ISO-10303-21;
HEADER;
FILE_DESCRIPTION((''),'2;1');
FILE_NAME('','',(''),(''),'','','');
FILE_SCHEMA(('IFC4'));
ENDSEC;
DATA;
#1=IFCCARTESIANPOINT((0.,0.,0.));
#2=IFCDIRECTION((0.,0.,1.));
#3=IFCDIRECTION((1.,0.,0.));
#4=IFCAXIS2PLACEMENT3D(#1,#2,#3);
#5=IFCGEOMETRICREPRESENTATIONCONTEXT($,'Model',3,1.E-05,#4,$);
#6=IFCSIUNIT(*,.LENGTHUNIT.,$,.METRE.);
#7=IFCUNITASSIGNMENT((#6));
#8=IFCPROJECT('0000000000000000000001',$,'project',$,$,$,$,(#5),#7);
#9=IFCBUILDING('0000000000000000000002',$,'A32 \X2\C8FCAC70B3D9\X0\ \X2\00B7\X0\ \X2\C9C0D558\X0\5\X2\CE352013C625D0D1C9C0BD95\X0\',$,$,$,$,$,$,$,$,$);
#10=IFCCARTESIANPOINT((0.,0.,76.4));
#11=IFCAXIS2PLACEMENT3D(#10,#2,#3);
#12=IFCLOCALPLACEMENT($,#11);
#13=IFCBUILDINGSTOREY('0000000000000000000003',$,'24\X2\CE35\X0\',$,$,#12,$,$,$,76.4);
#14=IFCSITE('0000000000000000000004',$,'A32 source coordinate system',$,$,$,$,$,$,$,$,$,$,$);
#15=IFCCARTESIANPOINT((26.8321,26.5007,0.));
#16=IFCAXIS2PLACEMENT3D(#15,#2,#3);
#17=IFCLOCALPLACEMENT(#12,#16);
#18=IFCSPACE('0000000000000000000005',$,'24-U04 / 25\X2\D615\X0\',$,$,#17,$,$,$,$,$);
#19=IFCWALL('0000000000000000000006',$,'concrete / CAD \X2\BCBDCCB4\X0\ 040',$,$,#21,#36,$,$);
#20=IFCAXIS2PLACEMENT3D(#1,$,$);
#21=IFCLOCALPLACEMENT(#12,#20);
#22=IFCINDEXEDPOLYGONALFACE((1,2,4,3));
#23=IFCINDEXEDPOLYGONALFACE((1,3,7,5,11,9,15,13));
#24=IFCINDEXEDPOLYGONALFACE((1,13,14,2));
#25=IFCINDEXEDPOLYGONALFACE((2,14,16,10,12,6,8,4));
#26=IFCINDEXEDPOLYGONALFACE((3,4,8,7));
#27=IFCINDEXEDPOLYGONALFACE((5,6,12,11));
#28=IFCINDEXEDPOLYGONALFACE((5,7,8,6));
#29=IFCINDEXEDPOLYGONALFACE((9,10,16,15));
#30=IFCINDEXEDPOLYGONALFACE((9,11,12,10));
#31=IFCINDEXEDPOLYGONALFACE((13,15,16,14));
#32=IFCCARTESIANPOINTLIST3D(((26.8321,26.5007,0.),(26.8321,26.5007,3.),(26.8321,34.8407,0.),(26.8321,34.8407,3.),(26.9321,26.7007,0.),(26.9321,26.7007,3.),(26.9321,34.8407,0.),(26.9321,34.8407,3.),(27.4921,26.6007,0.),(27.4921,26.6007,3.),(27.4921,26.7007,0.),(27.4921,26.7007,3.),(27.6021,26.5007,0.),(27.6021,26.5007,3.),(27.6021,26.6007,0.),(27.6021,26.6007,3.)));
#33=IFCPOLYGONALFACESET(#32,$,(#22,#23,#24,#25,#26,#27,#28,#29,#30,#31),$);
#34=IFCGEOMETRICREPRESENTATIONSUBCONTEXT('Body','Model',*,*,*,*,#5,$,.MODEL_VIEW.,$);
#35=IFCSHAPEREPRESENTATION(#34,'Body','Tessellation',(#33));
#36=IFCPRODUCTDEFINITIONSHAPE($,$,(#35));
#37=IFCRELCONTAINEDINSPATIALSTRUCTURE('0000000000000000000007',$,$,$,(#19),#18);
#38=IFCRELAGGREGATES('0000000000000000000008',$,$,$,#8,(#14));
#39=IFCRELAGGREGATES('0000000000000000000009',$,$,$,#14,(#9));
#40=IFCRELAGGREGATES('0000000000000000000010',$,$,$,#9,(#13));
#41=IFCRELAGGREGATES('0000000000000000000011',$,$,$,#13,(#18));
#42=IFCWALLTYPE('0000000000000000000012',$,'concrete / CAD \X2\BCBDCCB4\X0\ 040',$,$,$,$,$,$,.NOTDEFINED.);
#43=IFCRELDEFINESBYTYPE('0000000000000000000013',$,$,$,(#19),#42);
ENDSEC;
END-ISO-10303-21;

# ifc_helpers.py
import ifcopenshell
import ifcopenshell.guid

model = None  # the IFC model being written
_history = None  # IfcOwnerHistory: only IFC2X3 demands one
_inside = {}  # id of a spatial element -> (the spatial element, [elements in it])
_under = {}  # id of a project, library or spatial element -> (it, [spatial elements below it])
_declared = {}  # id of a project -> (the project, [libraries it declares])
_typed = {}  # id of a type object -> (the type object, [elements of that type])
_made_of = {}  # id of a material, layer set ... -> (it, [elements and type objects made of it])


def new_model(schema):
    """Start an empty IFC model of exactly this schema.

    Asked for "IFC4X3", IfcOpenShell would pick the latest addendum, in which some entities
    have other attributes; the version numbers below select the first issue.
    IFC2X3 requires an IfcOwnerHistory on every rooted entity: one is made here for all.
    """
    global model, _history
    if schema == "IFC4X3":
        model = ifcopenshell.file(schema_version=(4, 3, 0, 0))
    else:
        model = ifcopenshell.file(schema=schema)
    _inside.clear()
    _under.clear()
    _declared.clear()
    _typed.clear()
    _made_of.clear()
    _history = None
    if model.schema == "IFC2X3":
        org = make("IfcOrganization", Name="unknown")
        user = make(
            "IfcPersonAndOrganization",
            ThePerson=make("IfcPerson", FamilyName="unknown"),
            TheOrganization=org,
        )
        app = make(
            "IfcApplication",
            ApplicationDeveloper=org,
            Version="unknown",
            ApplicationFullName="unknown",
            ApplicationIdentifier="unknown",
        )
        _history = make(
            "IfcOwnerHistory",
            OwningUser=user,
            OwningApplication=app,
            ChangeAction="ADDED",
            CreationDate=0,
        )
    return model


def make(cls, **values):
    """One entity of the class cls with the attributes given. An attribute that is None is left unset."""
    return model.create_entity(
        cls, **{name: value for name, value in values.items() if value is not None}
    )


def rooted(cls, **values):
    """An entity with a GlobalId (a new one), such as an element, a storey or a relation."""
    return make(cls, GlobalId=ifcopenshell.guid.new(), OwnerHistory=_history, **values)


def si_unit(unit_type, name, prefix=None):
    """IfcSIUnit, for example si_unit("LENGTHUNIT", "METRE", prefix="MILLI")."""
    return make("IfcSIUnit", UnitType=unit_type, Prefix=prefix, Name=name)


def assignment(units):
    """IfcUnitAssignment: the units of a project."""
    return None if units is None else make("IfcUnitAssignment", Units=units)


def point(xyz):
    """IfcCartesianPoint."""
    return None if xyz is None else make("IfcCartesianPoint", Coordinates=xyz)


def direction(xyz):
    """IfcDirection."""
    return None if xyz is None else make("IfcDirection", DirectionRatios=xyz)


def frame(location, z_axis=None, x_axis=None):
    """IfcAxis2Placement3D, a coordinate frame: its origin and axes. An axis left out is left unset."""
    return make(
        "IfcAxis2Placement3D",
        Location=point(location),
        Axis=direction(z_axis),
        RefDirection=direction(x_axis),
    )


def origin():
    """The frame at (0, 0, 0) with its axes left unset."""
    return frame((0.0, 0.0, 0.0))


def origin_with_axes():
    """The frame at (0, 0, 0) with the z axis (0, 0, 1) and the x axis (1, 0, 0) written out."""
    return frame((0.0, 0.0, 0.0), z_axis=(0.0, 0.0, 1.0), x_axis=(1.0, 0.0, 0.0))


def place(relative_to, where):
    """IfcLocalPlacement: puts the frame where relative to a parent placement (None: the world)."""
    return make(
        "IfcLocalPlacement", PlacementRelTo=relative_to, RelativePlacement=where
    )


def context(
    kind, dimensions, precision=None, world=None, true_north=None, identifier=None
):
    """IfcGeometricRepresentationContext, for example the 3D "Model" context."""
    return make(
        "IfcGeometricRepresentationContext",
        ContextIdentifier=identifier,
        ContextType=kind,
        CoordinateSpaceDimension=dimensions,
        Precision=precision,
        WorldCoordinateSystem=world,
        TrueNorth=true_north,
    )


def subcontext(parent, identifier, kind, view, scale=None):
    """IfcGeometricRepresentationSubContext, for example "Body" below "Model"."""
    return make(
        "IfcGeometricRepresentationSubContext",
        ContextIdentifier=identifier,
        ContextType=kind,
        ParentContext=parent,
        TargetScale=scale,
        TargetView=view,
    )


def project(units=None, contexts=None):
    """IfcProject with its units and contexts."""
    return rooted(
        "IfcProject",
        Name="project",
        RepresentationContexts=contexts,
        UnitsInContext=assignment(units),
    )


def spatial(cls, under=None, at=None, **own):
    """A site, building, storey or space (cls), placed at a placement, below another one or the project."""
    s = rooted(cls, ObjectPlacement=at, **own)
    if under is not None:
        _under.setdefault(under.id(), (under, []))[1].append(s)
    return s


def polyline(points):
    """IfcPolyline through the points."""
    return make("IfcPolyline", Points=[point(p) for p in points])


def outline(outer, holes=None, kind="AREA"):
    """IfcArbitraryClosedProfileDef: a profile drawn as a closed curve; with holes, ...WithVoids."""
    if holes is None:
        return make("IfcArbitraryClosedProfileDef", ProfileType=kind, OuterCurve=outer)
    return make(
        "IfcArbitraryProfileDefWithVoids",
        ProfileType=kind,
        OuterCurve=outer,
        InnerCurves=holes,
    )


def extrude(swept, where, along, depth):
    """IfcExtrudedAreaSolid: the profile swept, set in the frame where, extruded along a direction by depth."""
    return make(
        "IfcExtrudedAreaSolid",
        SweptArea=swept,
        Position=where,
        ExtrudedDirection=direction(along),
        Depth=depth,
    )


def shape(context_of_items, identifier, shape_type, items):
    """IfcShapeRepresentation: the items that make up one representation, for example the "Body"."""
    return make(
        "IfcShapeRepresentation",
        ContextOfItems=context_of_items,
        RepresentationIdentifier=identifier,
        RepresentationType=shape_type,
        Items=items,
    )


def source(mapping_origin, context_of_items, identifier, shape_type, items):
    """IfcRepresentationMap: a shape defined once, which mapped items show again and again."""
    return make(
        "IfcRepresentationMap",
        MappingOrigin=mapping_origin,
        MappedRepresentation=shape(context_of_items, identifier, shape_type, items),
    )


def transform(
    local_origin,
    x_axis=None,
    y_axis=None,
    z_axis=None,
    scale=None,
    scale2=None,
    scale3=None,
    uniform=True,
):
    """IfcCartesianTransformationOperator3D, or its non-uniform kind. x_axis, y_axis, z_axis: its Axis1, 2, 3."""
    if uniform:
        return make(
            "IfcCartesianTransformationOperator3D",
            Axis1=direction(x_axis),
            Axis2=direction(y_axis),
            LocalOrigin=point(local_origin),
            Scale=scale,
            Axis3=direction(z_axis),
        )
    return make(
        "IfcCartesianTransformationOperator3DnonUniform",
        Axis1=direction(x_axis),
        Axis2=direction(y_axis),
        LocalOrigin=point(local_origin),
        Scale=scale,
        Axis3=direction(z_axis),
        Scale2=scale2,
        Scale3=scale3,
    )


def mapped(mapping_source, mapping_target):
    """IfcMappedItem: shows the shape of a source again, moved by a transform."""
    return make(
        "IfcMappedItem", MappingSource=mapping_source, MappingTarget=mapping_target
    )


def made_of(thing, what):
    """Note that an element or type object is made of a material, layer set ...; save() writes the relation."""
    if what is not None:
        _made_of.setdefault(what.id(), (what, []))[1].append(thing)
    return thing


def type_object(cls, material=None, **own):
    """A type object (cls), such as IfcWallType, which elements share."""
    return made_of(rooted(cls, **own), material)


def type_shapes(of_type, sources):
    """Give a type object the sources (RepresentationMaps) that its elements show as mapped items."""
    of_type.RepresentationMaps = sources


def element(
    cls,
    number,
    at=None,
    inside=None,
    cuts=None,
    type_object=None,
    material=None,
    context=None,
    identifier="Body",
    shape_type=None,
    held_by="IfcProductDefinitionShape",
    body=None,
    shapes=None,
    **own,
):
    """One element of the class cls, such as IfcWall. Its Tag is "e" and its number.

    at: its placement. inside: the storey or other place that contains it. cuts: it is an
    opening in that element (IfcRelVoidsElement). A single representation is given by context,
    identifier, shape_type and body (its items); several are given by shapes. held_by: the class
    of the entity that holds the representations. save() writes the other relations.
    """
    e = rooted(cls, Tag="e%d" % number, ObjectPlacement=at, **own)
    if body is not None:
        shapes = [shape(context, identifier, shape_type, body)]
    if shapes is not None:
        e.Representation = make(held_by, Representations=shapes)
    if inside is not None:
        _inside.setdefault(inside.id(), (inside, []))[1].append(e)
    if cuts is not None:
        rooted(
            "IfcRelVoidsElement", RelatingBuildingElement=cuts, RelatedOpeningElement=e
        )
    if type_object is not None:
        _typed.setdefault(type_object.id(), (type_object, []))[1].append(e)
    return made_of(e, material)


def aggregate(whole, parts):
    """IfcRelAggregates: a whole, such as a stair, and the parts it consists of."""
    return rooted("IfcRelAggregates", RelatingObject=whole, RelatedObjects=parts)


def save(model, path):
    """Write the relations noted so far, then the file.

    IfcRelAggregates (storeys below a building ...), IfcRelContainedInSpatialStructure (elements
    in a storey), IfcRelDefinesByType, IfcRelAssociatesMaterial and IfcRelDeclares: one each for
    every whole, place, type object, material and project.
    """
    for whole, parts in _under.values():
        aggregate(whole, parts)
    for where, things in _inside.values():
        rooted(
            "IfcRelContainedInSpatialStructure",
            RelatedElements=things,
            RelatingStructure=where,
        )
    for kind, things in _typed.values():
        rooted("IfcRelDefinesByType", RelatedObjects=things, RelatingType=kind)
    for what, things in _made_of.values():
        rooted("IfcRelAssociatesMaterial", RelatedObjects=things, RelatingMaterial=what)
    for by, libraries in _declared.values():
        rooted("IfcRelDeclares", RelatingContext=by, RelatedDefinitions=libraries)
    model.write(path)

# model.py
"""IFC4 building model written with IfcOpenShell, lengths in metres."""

from ifc_helpers import new_model, si_unit, frame, origin, origin_with_axes, place, context, subcontext, project, spatial, polyline, outline, extrude, source, transform, mapped, type_object, type_shapes, element, save


model = new_model("IFC4")

# Units and contexts
model_context = context("Model", 3, precision=1e-05, world=origin_with_axes())
body_context = subcontext(model_context, "Body", "Model", "MODEL_VIEW")
ifc_project = project(units=[si_unit("LENGTHUNIT", "METRE")], contexts=[model_context])

# Site, building, storey, space
site = spatial("IfcSite", under=ifc_project, Name="A32 source coordinate system")
building = spatial("IfcBuilding", under=site, Name="A32 주거동 · 지하5층–옥탑지붕")
storey_placement = place(None, frame((0.0, 0.0, 76.4), z_axis=(0.0, 0.0, 1.0), x_axis=(1.0, 0.0, 0.0)))
storey = spatial("IfcBuildingStorey", under=building, at=storey_placement, Name="24층", Elevation=76.4)
space_1_placement = place(storey_placement, frame((26.8321, 26.5007, 0.0), z_axis=(0.0, 0.0, 1.0), x_axis=(1.0, 0.0, 0.0)))
space_1 = spatial("IfcSpace", under=storey, at=space_1_placement, Name="24-U04 / 25형")

# Wall
wall_type_1 = type_object("IfcWallType", Name="concrete / CAD 벽체 040", PredefinedType="NOTDEFINED")
shared_shape_1 = source(origin(), body_context, "Body", "SweptSolid", [
    extrude(outline(polyline([(-0.1, 8.34), (0.1, 8.34), (0.1, 0.2), (0.66, 0.2), (0.66, 0.1), (0.77, 0.1), (0.77, 0.0), (0.0, 0.0), (0.0, 8.34), (-0.1, 8.34), (-0.1, 8.34)])), origin(), (0.0, 0.0, 1.0), 3.0),
])
type_shapes(wall_type_1, [shared_shape_1])
wall_1_placement = place(space_1_placement, origin_with_axes())
element("IfcWall", 1, at=wall_1_placement, inside=space_1, type_object=wall_type_1, Name="concrete / CAD 벽체 040", context=body_context, shape_type="MappedRepresentation", body=[
    mapped(shared_shape_1, transform((0.0, 0.0, 0.0), scale=1.0)),
])

save(model, "model.ifc")
